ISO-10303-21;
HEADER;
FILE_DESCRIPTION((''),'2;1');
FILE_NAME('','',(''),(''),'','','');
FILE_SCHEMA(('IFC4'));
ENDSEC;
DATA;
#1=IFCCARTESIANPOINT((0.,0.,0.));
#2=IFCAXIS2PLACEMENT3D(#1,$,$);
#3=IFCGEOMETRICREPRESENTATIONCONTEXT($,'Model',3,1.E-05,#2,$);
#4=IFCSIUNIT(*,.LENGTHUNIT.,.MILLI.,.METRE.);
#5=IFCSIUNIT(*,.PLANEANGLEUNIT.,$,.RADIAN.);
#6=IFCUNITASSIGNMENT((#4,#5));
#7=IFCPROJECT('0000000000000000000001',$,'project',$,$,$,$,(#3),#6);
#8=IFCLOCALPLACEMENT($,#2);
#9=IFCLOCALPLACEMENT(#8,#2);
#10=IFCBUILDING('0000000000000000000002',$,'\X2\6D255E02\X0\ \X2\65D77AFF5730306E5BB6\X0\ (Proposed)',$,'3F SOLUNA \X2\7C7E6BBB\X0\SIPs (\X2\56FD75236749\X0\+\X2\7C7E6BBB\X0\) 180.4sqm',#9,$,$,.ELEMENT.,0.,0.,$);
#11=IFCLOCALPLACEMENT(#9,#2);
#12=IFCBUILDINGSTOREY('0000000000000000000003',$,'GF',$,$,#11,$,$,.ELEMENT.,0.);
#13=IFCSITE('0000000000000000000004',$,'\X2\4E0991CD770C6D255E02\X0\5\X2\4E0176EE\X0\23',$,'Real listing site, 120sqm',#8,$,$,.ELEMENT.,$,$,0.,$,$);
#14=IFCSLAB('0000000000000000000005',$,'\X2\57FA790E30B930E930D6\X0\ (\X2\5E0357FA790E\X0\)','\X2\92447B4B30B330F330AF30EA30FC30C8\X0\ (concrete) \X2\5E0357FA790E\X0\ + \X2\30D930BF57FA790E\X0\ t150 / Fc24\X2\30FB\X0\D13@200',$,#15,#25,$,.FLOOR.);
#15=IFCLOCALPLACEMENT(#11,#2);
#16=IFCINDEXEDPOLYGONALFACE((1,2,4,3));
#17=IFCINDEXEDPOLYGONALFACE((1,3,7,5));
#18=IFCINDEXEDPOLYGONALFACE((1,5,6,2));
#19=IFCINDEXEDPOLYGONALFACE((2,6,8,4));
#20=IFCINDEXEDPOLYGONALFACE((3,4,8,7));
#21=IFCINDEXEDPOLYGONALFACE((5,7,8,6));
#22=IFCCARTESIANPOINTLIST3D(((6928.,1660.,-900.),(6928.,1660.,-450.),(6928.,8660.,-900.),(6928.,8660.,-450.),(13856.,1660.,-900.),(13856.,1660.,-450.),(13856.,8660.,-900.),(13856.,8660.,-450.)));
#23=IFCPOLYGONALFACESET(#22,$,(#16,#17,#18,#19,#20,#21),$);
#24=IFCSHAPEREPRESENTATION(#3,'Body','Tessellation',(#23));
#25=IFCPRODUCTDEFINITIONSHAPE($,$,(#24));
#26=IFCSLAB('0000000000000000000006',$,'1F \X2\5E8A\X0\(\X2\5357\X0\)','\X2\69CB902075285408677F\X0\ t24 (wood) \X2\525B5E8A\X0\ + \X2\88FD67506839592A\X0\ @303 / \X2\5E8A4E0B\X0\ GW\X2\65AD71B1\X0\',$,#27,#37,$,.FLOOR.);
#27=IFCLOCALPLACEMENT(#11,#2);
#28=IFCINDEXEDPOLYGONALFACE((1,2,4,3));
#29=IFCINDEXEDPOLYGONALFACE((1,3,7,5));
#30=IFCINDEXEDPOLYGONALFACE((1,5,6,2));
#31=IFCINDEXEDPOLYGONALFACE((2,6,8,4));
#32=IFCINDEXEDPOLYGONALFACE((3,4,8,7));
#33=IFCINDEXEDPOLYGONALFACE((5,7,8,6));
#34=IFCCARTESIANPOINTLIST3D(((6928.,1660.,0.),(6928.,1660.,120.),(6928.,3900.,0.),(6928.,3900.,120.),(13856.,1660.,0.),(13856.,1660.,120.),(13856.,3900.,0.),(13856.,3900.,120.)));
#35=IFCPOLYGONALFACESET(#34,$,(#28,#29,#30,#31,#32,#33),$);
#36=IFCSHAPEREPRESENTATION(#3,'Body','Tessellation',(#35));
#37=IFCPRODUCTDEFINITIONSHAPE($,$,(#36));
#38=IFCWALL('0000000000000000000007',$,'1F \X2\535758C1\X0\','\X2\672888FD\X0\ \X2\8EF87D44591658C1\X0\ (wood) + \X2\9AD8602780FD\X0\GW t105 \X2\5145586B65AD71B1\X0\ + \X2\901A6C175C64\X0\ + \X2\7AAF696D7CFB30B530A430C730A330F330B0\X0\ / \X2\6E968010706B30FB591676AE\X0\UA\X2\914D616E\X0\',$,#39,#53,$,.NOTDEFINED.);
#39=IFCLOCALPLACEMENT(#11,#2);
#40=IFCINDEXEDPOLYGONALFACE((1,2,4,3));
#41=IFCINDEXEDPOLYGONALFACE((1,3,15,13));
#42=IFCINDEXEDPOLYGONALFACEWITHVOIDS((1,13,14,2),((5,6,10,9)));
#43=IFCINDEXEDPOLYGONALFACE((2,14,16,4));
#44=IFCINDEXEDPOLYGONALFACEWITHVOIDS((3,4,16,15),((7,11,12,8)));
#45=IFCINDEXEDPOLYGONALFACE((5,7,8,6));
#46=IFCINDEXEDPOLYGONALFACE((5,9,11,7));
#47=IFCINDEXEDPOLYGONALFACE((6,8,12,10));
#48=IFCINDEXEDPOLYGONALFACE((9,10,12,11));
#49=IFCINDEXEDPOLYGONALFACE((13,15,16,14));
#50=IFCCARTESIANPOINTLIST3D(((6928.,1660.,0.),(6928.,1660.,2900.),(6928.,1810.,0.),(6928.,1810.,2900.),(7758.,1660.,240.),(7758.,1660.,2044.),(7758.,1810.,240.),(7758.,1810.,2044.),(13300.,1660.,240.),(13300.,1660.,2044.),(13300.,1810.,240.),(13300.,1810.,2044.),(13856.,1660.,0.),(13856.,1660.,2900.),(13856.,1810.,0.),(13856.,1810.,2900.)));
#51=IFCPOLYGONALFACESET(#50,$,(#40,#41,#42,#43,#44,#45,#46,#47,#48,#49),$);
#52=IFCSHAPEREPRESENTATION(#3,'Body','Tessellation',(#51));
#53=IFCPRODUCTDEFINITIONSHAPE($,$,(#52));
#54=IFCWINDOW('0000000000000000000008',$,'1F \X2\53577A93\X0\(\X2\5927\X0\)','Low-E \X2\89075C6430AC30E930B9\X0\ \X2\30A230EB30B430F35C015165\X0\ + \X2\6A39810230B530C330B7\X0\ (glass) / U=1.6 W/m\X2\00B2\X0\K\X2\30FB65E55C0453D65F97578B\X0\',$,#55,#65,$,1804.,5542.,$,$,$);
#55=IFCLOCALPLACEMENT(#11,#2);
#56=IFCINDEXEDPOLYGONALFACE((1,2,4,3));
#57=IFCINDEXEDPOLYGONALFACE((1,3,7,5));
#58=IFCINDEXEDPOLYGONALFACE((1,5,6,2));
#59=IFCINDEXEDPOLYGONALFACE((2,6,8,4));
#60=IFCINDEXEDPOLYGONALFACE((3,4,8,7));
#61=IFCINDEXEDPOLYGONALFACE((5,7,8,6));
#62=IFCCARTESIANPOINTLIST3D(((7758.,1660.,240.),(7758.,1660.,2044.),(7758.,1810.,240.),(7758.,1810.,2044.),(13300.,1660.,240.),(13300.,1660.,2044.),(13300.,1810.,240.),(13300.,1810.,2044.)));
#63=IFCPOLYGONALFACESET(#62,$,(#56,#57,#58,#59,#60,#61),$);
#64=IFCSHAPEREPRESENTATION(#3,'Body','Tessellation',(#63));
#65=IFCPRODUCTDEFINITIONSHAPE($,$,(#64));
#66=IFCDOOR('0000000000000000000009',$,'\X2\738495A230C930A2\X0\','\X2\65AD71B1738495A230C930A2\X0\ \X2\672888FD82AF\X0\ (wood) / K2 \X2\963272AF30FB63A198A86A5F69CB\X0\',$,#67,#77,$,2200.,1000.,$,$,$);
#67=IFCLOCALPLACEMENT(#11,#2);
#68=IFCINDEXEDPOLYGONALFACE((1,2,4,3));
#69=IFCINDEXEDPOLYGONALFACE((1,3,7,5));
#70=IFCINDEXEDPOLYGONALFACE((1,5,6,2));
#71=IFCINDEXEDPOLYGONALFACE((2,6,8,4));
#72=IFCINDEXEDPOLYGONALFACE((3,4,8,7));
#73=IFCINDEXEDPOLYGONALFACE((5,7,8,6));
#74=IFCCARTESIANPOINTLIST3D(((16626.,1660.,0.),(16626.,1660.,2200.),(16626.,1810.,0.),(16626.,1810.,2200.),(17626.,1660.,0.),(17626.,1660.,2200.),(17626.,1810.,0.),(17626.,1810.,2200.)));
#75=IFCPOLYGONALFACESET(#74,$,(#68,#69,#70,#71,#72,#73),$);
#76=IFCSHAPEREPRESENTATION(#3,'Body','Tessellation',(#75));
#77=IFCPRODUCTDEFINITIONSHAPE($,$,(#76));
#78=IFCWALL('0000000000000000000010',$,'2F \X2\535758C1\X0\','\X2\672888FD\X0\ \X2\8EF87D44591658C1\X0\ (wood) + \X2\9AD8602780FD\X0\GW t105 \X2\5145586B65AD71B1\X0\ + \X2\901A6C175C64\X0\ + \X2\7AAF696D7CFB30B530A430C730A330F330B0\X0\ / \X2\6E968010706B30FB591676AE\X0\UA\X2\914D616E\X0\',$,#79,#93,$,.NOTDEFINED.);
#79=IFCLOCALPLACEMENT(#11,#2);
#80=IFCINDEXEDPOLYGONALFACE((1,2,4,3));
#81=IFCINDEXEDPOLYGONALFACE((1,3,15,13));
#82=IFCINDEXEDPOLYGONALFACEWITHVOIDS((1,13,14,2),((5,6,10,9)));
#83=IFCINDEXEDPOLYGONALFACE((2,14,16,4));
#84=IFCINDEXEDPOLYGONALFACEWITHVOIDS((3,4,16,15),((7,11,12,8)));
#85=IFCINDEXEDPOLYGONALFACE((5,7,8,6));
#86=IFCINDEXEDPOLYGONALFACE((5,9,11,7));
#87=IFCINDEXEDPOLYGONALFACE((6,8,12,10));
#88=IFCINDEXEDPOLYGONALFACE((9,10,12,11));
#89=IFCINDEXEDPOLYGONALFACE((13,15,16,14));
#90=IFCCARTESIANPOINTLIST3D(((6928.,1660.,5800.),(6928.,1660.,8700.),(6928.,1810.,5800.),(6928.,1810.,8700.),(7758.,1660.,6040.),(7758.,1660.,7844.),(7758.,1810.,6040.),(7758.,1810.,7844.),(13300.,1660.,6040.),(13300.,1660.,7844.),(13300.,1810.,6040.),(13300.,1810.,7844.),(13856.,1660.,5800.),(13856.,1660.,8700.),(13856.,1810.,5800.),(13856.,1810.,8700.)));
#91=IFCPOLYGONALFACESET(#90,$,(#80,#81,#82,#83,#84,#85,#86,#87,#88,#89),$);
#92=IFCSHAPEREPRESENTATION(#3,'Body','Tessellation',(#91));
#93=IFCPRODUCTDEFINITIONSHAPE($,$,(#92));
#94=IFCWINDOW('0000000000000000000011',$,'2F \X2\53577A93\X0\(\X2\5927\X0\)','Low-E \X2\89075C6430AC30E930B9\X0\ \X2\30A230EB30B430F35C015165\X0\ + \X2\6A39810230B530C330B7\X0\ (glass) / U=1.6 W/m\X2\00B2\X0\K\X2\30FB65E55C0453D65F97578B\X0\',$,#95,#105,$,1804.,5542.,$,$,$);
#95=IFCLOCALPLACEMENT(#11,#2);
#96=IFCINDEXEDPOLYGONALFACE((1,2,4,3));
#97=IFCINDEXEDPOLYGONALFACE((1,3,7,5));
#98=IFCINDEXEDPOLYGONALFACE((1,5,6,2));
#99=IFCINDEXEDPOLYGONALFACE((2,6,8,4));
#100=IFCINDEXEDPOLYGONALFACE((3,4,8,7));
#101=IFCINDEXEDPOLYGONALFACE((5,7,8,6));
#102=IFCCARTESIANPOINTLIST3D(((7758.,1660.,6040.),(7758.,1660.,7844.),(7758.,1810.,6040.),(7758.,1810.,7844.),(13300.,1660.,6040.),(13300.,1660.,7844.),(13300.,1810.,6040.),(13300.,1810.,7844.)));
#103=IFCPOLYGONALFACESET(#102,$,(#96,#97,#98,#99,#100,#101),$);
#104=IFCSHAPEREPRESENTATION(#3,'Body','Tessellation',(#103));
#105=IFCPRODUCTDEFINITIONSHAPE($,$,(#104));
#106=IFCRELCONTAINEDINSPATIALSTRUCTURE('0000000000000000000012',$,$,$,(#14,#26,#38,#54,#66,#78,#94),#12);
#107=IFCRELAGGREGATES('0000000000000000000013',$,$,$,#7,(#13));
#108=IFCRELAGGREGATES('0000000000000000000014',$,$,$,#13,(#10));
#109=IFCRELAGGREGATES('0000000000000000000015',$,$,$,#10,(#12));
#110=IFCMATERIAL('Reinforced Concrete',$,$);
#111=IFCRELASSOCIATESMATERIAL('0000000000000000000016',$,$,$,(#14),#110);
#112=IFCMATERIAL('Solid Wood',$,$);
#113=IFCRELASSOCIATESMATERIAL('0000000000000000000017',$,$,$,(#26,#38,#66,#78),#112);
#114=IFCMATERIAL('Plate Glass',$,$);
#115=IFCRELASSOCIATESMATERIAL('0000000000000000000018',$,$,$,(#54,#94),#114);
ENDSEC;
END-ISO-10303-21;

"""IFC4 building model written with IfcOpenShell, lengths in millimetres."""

from ifc_helpers import new_model, si_unit, frame, frame_2d, origin, place, context, project, spatial, rectangle, extrude, material, element, fill, save


model = new_model("IFC4")

# Units and contexts
model_context = context("Model", 3, precision=1e-05, world=origin())
ifc_project = project(units=[si_unit("LENGTHUNIT", "METRE", prefix="MILLI"), si_unit("PLANEANGLEUNIT", "RADIAN")], contexts=[model_context])

# Site, building, storey
site_placement = place(None, origin())
site = spatial("IfcSite", under=ifc_project, at=site_placement, Name="三重県津市5丁目23", ObjectType="Real listing site, 120sqm", CompositionType="ELEMENT", RefElevation=0.0)
building_placement = place(site_placement, origin())
building = spatial("IfcBuilding", under=site, at=building_placement, Name="津市 旗竿地の家 (Proposed)", ObjectType="3F SOLUNA 籾殻SIPs (国産杉+籾殻) 180.4sqm", CompositionType="ELEMENT", ElevationOfRefHeight=0.0, ElevationOfTerrain=0.0)
storey_placement = place(building_placement, origin())
storey = spatial("IfcBuildingStorey", under=building, at=storey_placement, Name="GF", CompositionType="ELEMENT", Elevation=0.0)

# Slabs
ifc_material_1 = material(Name="Reinforced Concrete")
slab_1_placement = place(storey_placement, frame((3464.0, 830.0, -450.0)))
element("IfcSlab", 1, at=slab_1_placement, inside=storey, material=ifc_material_1, Name="基礎スラブ (布基礎)", Description="鉄筋コンクリート (concrete) 布基礎 + ベタ基礎 t150 / Fc24・D13@200", PredefinedType="FLOOR", context=model_context, shape_type="SweptSolid", body=[
    extrude(rectangle(XDim=6928.0, YDim=7000.0, at=frame_2d((3464.0, 3500.0))), frame((3464.0, 830.0, -450.0)), (0.0, 0.0, 1.0), 450.0),
])
ifc_material_2 = material(Name="Solid Wood")
slab_2_placement = place(storey_placement, frame((3464.0, 830.0, 0.0)))
element("IfcSlab", 2, at=slab_2_placement, inside=storey, material=ifc_material_2, Name="1F 床(南)", Description="構造用合板 t24 (wood) 剛床 + 製材根太 @303 / 床下 GW断熱", PredefinedType="FLOOR", context=model_context, shape_type="SweptSolid", body=[
    extrude(rectangle(XDim=6928.0, YDim=2240.0, at=frame_2d((3464.0, 1120.0))), frame((3464.0, 830.0, 0.0)), (0.0, 0.0, 1.0), 120.0),
])

# Wall, openings, window, door
wall_1_placement = place(storey_placement, frame((3464.0, 830.0, 0.0)))
wall_1 = element("IfcWall", 3, at=wall_1_placement, inside=storey, material=ifc_material_2, Name="1F 南壁", Description="木製 軸組外壁 (wood) + 高性能GW t105 充填断熱 + 通気層 + 窯業系サイディング / 準耐火・外皮UA配慮", PredefinedType="NOTDEFINED", context=model_context, shape_type="SweptSolid", body=[
    extrude(rectangle(XDim=6928.0, YDim=150.0, at=frame_2d((3464.0, 75.0))), frame((3464.0, 830.0, 0.0)), (0.0, 0.0, 1.0), 2900.0),
])
opening_1_placement = place(storey_placement, frame((3879.0, 830.0, 120.0)))
opening_1 = element("IfcOpeningElement", 4, at=opening_1_placement, cuts=wall_1, PredefinedType="NOTDEFINED", context=model_context, shape_type="SweptSolid", body=[
    extrude(rectangle(XDim=5542.0, YDim=150.0, at=frame_2d((2771.0, 75.0))), frame((3879.0, 830.0, 120.0)), (0.0, 0.0, 1.0), 1804.0),
])
opening_2_placement = place(storey_placement, frame((8313.0, 830.0, 0.0)))
opening_2 = element("IfcOpeningElement", 5, at=opening_2_placement, cuts=wall_1, PredefinedType="NOTDEFINED", context=model_context, shape_type="SweptSolid", body=[
    extrude(rectangle(XDim=1000.0, YDim=150.0, at=frame_2d((500.0, 75.0))), frame((8313.0, 830.0, 0.0)), (0.0, 0.0, 1.0), 2200.0),
])
ifc_material_3 = material(Name="Plate Glass")
window_1_placement = place(storey_placement, frame((3879.0, 830.0, 120.0)))
window_1 = element("IfcWindow", 6, at=window_1_placement, inside=storey, material=ifc_material_3, Name="1F 南窓(大)", Description="Low-E 複層ガラス アルゴン封入 + 樹脂サッシ (glass) / U=1.6 W/m²K・日射取得型", OverallHeight=1804.0, OverallWidth=5542.0, context=model_context, shape_type="SweptSolid", body=[
    extrude(rectangle(XDim=5542.0, YDim=150.0, at=frame_2d((2771.0, 75.0))), frame((3879.0, 830.0, 120.0)), (0.0, 0.0, 1.0), 1804.0),
])
fill(opening_1, window_1)
door_placement = place(storey_placement, frame((8313.0, 830.0, 0.0)))
door = element("IfcDoor", 7, at=door_placement, inside=storey, material=ifc_material_2, Name="玄関ドア", Description="断熱玄関ドア 木製芯 (wood) / K2 防犯・採風機構", OverallHeight=2200.0, OverallWidth=1000.0, context=model_context, shape_type="SweptSolid", body=[
    extrude(rectangle(XDim=1000.0, YDim=150.0, at=frame_2d((500.0, 75.0))), frame((8313.0, 830.0, 0.0)), (0.0, 0.0, 1.0), 2200.0),
])
fill(opening_2, door)

# Wall, opening, window
wall_2_placement = place(storey_placement, frame((3464.0, 830.0, 2900.0)))
wall_2 = element("IfcWall", 8, at=wall_2_placement, inside=storey, material=ifc_material_2, Name="2F 南壁", Description="木製 軸組外壁 (wood) + 高性能GW t105 充填断熱 + 通気層 + 窯業系サイディング / 準耐火・外皮UA配慮", PredefinedType="NOTDEFINED", context=model_context, shape_type="SweptSolid", body=[
    extrude(rectangle(XDim=6928.0, YDim=150.0, at=frame_2d((3464.0, 75.0))), frame((3464.0, 830.0, 2900.0)), (0.0, 0.0, 1.0), 2900.0),
])
opening_3_placement = place(storey_placement, frame((3879.0, 830.0, 3020.0)))
opening_3 = element("IfcOpeningElement", 9, at=opening_3_placement, cuts=wall_2, PredefinedType="NOTDEFINED", context=model_context, shape_type="SweptSolid", body=[
    extrude(rectangle(XDim=5542.0, YDim=150.0, at=frame_2d((2771.0, 75.0))), frame((3879.0, 830.0, 3020.0)), (0.0, 0.0, 1.0), 1804.0),
])
window_2_placement = place(storey_placement, frame((3879.0, 830.0, 3020.0)))
window_2 = element("IfcWindow", 10, at=window_2_placement, inside=storey, material=ifc_material_3, Name="2F 南窓(大)", Description="Low-E 複層ガラス アルゴン封入 + 樹脂サッシ (glass) / U=1.6 W/m²K・日射取得型", OverallHeight=1804.0, OverallWidth=5542.0, context=model_context, shape_type="SweptSolid", body=[
    extrude(rectangle(XDim=5542.0, YDim=150.0, at=frame_2d((2771.0, 75.0))), frame((3879.0, 830.0, 3020.0)), (0.0, 0.0, 1.0), 1804.0),
])
fill(opening_3, window_2)

save(model, "model.ifc")
